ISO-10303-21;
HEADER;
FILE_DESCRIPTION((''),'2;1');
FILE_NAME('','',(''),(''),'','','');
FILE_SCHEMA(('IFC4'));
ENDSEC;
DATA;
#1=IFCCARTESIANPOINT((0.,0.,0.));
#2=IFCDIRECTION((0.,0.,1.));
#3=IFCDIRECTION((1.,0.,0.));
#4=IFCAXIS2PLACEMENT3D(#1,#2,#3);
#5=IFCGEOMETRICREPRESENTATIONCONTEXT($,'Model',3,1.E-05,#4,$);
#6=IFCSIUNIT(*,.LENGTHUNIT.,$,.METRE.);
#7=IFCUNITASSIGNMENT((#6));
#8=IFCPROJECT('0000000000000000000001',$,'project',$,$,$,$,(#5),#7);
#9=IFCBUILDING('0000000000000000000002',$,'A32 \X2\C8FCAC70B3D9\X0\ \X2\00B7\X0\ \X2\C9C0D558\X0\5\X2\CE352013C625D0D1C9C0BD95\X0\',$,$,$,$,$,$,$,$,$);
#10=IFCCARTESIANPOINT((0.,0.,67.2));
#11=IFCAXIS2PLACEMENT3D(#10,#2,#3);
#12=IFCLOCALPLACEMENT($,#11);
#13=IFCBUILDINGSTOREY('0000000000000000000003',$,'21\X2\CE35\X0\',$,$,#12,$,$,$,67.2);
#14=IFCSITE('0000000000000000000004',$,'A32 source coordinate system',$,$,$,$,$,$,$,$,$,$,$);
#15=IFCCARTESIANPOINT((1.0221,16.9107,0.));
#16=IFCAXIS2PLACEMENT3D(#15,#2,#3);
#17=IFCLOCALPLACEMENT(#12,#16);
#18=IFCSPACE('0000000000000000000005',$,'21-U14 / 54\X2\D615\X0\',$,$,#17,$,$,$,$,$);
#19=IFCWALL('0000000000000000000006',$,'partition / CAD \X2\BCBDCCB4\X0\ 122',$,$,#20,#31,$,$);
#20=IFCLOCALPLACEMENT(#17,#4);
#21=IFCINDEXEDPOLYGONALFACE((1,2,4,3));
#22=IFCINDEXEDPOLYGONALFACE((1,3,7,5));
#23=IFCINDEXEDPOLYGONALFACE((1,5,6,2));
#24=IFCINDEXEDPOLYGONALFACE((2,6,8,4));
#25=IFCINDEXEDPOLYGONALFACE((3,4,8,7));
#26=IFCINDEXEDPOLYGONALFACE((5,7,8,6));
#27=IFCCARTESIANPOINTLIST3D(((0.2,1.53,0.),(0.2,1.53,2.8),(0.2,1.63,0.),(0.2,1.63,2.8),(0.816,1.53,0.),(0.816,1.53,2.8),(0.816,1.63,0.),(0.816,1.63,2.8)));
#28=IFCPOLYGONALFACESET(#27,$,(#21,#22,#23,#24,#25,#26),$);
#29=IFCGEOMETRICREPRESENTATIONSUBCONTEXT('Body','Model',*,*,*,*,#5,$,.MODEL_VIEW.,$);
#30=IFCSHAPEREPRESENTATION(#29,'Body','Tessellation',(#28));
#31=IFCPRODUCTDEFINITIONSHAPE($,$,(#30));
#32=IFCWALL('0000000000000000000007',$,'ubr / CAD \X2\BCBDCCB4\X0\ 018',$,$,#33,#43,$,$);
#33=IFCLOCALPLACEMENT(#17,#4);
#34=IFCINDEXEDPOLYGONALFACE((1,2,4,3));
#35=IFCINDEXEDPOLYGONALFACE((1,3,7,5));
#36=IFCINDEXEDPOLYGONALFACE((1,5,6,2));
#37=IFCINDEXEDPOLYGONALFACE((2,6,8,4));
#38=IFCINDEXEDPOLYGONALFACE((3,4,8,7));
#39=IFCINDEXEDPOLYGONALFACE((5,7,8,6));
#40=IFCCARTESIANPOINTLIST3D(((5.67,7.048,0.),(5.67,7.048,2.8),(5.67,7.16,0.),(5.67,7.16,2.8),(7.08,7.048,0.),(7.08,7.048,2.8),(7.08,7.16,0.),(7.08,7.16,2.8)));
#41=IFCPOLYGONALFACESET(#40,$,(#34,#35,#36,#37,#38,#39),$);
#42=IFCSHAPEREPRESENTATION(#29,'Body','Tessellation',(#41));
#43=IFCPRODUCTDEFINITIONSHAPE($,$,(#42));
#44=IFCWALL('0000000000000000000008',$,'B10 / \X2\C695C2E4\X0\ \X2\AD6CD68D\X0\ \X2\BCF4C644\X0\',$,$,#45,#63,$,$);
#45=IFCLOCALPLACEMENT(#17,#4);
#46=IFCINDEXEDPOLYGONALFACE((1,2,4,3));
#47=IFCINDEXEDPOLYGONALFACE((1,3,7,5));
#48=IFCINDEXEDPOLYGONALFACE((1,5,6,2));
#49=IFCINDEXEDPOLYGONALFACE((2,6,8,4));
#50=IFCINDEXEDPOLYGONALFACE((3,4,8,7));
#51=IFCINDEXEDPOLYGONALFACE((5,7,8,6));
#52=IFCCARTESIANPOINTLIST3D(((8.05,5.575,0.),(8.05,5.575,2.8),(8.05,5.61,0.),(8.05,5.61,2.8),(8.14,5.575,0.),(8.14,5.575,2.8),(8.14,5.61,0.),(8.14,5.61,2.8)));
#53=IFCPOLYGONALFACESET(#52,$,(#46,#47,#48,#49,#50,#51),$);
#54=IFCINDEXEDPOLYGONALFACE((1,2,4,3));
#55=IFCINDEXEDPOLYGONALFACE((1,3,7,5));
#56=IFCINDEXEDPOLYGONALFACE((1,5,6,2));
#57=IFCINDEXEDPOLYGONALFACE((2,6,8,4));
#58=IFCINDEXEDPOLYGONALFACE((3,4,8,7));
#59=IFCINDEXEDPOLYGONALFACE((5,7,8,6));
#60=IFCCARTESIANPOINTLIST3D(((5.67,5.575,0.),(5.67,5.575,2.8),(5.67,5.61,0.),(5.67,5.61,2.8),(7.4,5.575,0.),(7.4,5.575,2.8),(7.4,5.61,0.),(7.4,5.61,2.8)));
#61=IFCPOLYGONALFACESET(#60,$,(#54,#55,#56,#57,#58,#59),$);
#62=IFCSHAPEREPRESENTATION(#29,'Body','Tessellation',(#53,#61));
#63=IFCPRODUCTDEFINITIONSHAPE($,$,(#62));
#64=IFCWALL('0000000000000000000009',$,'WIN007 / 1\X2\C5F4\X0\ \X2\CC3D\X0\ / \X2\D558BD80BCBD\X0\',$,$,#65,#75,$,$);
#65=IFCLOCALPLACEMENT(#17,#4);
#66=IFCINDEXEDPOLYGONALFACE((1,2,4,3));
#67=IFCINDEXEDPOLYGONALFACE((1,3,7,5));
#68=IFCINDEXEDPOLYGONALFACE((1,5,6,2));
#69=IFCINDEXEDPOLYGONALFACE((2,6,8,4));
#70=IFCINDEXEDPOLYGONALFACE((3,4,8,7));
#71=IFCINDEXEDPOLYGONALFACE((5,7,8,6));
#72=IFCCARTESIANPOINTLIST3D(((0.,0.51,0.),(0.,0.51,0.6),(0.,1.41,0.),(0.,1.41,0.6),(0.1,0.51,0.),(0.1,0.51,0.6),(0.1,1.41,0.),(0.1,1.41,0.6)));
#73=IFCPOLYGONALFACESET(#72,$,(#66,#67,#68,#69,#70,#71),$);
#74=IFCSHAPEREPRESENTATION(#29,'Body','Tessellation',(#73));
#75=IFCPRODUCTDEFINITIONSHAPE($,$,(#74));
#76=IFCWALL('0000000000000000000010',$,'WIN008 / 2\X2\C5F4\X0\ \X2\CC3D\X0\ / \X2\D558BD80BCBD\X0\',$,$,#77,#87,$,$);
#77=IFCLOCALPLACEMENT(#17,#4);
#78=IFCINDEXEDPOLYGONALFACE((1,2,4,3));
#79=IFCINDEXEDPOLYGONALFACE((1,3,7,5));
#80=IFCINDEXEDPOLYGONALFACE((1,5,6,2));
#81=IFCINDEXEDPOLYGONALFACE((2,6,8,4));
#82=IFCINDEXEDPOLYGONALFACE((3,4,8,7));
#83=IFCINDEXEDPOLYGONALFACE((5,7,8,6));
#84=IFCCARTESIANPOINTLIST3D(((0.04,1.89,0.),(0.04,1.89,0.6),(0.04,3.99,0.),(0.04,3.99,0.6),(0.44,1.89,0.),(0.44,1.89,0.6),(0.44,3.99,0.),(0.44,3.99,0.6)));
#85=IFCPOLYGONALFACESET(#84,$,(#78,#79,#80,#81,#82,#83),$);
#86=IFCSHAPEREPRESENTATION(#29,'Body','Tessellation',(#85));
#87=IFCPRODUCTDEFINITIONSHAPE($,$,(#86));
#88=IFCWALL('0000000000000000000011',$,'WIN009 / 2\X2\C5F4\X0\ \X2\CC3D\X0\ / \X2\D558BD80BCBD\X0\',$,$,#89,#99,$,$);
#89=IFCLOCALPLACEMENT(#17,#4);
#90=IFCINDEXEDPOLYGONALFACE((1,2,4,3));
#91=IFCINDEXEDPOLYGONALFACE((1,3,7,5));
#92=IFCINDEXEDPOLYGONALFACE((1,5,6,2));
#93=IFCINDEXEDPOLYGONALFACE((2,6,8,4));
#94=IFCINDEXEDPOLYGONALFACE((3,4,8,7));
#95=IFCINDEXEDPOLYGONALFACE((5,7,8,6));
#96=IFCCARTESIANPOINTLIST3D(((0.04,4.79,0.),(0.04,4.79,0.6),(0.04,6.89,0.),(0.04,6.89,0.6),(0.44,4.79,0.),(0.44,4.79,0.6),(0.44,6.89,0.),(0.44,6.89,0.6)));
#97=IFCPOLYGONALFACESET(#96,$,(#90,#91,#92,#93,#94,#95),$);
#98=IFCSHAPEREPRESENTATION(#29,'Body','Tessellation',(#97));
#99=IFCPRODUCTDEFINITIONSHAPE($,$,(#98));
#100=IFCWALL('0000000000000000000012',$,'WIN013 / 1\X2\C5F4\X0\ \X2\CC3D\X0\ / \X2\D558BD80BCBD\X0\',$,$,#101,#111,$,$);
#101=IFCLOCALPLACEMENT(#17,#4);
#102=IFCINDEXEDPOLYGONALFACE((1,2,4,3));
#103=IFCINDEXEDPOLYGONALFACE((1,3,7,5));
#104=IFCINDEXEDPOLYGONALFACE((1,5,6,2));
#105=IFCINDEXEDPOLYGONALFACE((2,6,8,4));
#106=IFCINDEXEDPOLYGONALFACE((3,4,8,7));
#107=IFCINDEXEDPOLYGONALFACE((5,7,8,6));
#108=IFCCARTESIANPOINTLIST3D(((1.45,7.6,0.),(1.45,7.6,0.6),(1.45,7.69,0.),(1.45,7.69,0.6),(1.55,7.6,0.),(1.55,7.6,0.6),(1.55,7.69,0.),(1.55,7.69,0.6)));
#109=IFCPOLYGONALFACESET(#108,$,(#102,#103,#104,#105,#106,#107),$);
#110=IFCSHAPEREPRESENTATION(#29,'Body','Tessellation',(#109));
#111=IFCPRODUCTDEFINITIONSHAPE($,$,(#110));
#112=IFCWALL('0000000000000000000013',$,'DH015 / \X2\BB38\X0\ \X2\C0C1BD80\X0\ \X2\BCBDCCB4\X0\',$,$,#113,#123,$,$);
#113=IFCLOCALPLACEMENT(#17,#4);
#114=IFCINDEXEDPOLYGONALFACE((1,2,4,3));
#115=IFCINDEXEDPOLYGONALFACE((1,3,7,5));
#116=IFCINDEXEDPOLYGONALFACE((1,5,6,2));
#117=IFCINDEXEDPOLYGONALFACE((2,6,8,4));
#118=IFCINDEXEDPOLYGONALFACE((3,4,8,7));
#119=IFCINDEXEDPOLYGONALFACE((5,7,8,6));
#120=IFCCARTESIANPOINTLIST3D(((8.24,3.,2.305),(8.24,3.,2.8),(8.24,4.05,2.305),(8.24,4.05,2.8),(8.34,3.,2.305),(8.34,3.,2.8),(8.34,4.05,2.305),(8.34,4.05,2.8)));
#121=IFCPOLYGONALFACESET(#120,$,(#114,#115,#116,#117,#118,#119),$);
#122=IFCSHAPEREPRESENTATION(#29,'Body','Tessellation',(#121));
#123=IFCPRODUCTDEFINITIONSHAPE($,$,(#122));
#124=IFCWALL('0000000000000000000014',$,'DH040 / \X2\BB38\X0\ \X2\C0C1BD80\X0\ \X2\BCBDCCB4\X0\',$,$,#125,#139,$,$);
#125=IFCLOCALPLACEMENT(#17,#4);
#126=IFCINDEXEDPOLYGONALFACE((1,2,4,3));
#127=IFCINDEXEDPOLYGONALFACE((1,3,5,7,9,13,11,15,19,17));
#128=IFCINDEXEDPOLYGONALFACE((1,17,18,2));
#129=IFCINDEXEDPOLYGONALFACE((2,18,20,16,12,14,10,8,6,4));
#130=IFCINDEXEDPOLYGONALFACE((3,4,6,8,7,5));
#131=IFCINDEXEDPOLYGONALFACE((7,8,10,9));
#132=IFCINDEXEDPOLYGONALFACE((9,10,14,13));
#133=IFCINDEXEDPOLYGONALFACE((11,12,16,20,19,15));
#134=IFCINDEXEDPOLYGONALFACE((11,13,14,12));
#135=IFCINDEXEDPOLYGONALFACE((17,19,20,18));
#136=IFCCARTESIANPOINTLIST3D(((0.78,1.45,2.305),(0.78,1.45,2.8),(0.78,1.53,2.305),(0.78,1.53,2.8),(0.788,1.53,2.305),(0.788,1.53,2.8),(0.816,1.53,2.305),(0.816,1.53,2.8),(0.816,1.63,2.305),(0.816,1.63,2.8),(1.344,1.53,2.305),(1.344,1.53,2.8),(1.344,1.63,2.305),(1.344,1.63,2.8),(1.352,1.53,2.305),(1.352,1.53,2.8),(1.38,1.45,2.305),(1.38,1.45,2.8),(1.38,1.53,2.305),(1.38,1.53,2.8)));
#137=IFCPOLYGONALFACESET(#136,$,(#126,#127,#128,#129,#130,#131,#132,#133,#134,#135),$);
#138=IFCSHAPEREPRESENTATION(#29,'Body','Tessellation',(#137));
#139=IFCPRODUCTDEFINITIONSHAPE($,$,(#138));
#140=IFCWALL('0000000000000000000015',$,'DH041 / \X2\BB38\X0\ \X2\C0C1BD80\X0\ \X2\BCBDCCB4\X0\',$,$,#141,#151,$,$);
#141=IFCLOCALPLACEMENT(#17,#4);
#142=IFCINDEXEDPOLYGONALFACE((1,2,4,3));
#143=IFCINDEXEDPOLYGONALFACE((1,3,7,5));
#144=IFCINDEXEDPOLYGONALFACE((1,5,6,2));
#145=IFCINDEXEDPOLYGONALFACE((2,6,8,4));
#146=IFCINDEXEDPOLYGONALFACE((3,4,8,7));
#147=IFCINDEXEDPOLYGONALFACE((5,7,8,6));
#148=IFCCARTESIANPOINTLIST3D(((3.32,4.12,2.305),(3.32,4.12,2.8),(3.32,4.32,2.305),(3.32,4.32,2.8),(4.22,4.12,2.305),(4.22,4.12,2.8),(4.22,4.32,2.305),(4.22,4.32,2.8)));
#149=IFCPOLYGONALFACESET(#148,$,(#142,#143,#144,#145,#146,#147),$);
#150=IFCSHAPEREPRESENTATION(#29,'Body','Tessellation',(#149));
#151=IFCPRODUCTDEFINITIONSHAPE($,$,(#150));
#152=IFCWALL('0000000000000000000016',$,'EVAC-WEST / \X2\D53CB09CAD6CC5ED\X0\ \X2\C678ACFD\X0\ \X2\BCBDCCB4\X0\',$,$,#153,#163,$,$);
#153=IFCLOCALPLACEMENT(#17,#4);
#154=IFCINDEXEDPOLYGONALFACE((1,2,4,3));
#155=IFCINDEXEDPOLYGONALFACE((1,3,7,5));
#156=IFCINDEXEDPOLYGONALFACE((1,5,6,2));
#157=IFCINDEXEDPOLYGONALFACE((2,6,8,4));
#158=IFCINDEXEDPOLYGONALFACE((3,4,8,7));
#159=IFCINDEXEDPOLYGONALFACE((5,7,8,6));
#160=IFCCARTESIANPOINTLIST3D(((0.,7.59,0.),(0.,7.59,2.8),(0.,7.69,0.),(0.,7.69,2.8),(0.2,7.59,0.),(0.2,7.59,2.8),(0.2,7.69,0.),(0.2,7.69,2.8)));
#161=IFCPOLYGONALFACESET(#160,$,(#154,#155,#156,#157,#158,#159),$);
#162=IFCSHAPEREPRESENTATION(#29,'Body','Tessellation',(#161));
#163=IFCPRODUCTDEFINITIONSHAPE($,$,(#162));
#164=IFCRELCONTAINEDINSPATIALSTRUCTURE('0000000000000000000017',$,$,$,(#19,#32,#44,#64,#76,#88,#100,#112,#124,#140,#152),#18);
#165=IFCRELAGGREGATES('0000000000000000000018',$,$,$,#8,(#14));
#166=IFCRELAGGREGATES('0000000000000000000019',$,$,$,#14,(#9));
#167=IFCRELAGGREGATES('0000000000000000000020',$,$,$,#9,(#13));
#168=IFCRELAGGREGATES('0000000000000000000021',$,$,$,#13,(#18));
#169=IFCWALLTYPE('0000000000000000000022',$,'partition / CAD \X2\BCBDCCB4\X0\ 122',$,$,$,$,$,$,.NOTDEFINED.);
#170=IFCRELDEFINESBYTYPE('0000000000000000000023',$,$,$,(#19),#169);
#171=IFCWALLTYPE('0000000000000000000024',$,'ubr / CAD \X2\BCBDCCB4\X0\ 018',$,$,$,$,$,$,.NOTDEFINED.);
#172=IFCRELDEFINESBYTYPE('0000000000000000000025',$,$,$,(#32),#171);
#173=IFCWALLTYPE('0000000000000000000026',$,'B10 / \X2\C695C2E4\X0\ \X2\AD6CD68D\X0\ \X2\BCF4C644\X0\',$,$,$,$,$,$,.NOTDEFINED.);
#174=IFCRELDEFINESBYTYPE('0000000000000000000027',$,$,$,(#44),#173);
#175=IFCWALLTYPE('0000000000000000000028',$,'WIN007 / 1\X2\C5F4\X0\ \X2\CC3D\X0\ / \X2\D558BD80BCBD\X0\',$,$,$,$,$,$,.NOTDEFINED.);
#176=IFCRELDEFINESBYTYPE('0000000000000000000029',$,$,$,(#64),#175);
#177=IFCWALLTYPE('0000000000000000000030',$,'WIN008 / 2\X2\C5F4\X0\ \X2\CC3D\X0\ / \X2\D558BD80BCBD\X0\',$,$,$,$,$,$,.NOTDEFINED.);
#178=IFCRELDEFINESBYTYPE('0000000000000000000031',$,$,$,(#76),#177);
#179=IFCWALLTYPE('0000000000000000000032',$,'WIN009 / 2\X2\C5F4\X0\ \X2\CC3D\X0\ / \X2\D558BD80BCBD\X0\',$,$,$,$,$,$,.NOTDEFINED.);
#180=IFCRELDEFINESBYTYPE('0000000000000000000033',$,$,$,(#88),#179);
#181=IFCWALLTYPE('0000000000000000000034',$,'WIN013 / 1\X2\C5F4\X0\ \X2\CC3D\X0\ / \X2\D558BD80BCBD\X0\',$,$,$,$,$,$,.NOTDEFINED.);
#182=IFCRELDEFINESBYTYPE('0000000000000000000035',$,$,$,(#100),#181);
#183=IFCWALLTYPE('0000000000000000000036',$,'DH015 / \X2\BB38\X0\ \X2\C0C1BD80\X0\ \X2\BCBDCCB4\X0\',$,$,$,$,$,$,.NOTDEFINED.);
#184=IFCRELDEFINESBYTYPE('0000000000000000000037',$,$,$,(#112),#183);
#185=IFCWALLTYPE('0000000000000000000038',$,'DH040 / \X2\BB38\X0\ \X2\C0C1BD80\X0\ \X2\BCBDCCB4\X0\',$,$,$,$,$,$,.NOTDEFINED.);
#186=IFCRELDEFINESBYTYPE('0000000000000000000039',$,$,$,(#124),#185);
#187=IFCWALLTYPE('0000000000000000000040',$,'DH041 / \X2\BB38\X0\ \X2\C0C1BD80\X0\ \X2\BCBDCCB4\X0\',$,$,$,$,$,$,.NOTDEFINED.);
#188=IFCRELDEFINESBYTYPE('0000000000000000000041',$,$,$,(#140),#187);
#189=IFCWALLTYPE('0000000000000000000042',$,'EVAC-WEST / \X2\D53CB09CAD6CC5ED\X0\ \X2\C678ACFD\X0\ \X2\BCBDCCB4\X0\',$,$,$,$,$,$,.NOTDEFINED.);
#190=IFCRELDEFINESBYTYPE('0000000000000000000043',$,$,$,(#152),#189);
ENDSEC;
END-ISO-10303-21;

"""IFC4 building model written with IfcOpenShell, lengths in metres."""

from ifc_helpers import new_model, si_unit, frame, origin, origin_with_axes, place, context, subcontext, project, spatial, polyline, outline, extrude, source, transform, mapped, type_object, type_shapes, element, save


model = new_model("IFC4")

# Units and contexts
model_context = context("Model", 3, precision=1e-05, world=origin_with_axes())
body_context = subcontext(model_context, "Body", "Model", "MODEL_VIEW")
ifc_project = project(units=[si_unit("LENGTHUNIT", "METRE")], contexts=[model_context])

# Site, building, storey, space
site = spatial("IfcSite", under=ifc_project, Name="A32 source coordinate system")
building = spatial("IfcBuilding", under=site, Name="A32 주거동 · 지하5층–옥탑지붕")
storey_placement = place(None, frame((0.0, 0.0, 67.2), z_axis=(0.0, 0.0, 1.0), x_axis=(1.0, 0.0, 0.0)))
storey = spatial("IfcBuildingStorey", under=building, at=storey_placement, Name="21층", Elevation=67.2)
space_placement = place(storey_placement, frame((1.0221, 16.9107, 0.0), z_axis=(0.0, 0.0, 1.0), x_axis=(1.0, 0.0, 0.0)))
space = spatial("IfcSpace", under=storey, at=space_placement, Name="21-U14 / 54형")

# Walls
wall_type_1 = type_object("IfcWallType", Name="partition / CAD 벽체 122", PredefinedType="NOTDEFINED")
shared_shape_1 = source(origin(), body_context, "Body", "SweptSolid", [
    extrude(outline(polyline([(0.816, 1.63), (0.816, 1.53), (0.2, 1.53), (0.2, 1.63), (0.816, 1.63)])), origin(), (0.0, 0.0, 1.0), 2.8),
])
type_shapes(wall_type_1, [shared_shape_1])
wall_1_placement = place(space_placement, origin_with_axes())
element("IfcWall", 1, at=wall_1_placement, inside=space, type_object=wall_type_1, Name="partition / CAD 벽체 122", context=body_context, shape_type="MappedRepresentation", body=[
    mapped(shared_shape_1, transform((0.0, 0.0, 0.0), scale=1.0)),
])
wall_type_2 = type_object("IfcWallType", Name="ubr / CAD 벽체 018", PredefinedType="NOTDEFINED")
shared_shape_2 = source(origin(), body_context, "Body", "SweptSolid", [
    extrude(outline(polyline([(5.67, 7.16), (7.08, 7.16), (7.08, 7.048), (5.67, 7.048), (5.67, 7.16)])), origin(), (0.0, 0.0, 1.0), 2.8),
])
type_shapes(wall_type_2, [shared_shape_2])
wall_2_placement = place(space_placement, origin_with_axes())
element("IfcWall", 2, at=wall_2_placement, inside=space, type_object=wall_type_2, Name="ubr / CAD 벽체 018", context=body_context, shape_type="MappedRepresentation", body=[
    mapped(shared_shape_2, transform((0.0, 0.0, 0.0), scale=1.0)),
])
wall_type_3 = type_object("IfcWallType", Name="B10 / 욕실 구획 보완", PredefinedType="NOTDEFINED")
shared_shape_3 = source(origin(), body_context, "Body", "SweptSolid", [
    extrude(outline(polyline([(8.14, 5.575), (8.05, 5.575), (8.05, 5.61), (8.14, 5.61), (8.14, 5.575)])), origin(), (0.0, 0.0, 1.0), 2.8),
    extrude(outline(polyline([(7.4, 5.575), (5.67, 5.575), (5.67, 5.61), (7.4, 5.61), (7.4, 5.575)])), origin(), (0.0, 0.0, 1.0), 2.8),
])
type_shapes(wall_type_3, [shared_shape_3])
wall_3_placement = place(space_placement, origin_with_axes())
element("IfcWall", 3, at=wall_3_placement, inside=space, type_object=wall_type_3, Name="B10 / 욕실 구획 보완", context=body_context, shape_type="MappedRepresentation", body=[
    mapped(shared_shape_3, transform((0.0, 0.0, 0.0), scale=1.0)),
])
wall_type_4 = type_object("IfcWallType", Name="WIN007 / 1열 창 / 하부벽", PredefinedType="NOTDEFINED")
shared_shape_4 = source(origin(), body_context, "Body", "SweptSolid", [
    extrude(outline(polyline([(0.1, 1.41), (0.1, 0.51), (0.0, 0.51), (0.0, 1.41), (0.1, 1.41)])), origin(), (0.0, 0.0, 1.0), 0.6),
])
type_shapes(wall_type_4, [shared_shape_4])
wall_4_placement = place(space_placement, origin_with_axes())
element("IfcWall", 4, at=wall_4_placement, inside=space, type_object=wall_type_4, Name="WIN007 / 1열 창 / 하부벽", context=body_context, shape_type="MappedRepresentation", body=[
    mapped(shared_shape_4, transform((0.0, 0.0, 0.0), scale=1.0)),
])
wall_type_5 = type_object("IfcWallType", Name="WIN008 / 2열 창 / 하부벽", PredefinedType="NOTDEFINED")
shared_shape_5 = source(origin(), body_context, "Body", "SweptSolid", [
    extrude(outline(polyline([(0.44, 3.99), (0.44, 1.89), (0.04, 1.89), (0.04, 3.99), (0.44, 3.99)])), origin(), (0.0, 0.0, 1.0), 0.6),
])
type_shapes(wall_type_5, [shared_shape_5])
wall_5_placement = place(space_placement, origin_with_axes())
element("IfcWall", 5, at=wall_5_placement, inside=space, type_object=wall_type_5, Name="WIN008 / 2열 창 / 하부벽", context=body_context, shape_type="MappedRepresentation", body=[
    mapped(shared_shape_5, transform((0.0, 0.0, 0.0), scale=1.0)),
])
wall_type_6 = type_object("IfcWallType", Name="WIN009 / 2열 창 / 하부벽", PredefinedType="NOTDEFINED")
shared_shape_6 = source(origin(), body_context, "Body", "SweptSolid", [
    extrude(outline(polyline([(0.44, 6.89), (0.44, 4.79), (0.04, 4.79), (0.04, 6.89), (0.44, 6.89)])), origin(), (0.0, 0.0, 1.0), 0.6),
])
type_shapes(wall_type_6, [shared_shape_6])
wall_6_placement = place(space_placement, origin_with_axes())
element("IfcWall", 6, at=wall_6_placement, inside=space, type_object=wall_type_6, Name="WIN009 / 2열 창 / 하부벽", context=body_context, shape_type="MappedRepresentation", body=[
    mapped(shared_shape_6, transform((0.0, 0.0, 0.0), scale=1.0)),
])
wall_type_7 = type_object("IfcWallType", Name="WIN013 / 1열 창 / 하부벽", PredefinedType="NOTDEFINED")
shared_shape_7 = source(origin(), body_context, "Body", "SweptSolid", [
    extrude(outline(polyline([(1.55, 7.6), (1.45, 7.6), (1.45, 7.69), (1.55, 7.69), (1.55, 7.6)])), origin(), (0.0, 0.0, 1.0), 0.6),
])
type_shapes(wall_type_7, [shared_shape_7])
wall_7_placement = place(space_placement, origin_with_axes())
element("IfcWall", 7, at=wall_7_placement, inside=space, type_object=wall_type_7, Name="WIN013 / 1열 창 / 하부벽", context=body_context, shape_type="MappedRepresentation", body=[
    mapped(shared_shape_7, transform((0.0, 0.0, 0.0), scale=1.0)),
])
wall_type_8 = type_object("IfcWallType", Name="DH015 / 문 상부 벽체", PredefinedType="NOTDEFINED")
shared_shape_8 = source(origin(), body_context, "Body", "SweptSolid", [
    extrude(outline(polyline([(8.34, 3.0), (8.24, 3.0), (8.24, 4.05), (8.34, 4.05), (8.34, 3.0)])), frame((0.0, 0.0, 2.305)), (0.0, 0.0, 1.0), 0.495),
])
type_shapes(wall_type_8, [shared_shape_8])
wall_8_placement = place(space_placement, origin_with_axes())
element("IfcWall", 8, at=wall_8_placement, inside=space, type_object=wall_type_8, Name="DH015 / 문 상부 벽체", context=body_context, shape_type="MappedRepresentation", body=[
    mapped(shared_shape_8, transform((0.0, 0.0, 0.0), scale=1.0)),
])
wall_type_9 = type_object("IfcWallType", Name="DH040 / 문 상부 벽체", PredefinedType="NOTDEFINED")
shared_shape_9 = source(origin(), body_context, "Body", "SweptSolid", [
    extrude(outline(polyline([(0.816, 1.63), (1.344, 1.63), (1.344, 1.53), (1.352, 1.53), (1.38, 1.53), (1.38, 1.45), (0.78, 1.45), (0.78, 1.53), (0.788, 1.53), (0.816, 1.53), (0.816, 1.63)])), frame((0.0, 0.0, 2.305)), (0.0, 0.0, 1.0), 0.495),
])
type_shapes(wall_type_9, [shared_shape_9])
wall_9_placement = place(space_placement, origin_with_axes())
element("IfcWall", 9, at=wall_9_placement, inside=space, type_object=wall_type_9, Name="DH040 / 문 상부 벽체", context=body_context, shape_type="MappedRepresentation", body=[
    mapped(shared_shape_9, transform((0.0, 0.0, 0.0), scale=1.0)),
])
wall_type_10 = type_object("IfcWallType", Name="DH041 / 문 상부 벽체", PredefinedType="NOTDEFINED")
shared_shape_10 = source(origin(), body_context, "Body", "SweptSolid", [
    extrude(outline(polyline([(4.22, 4.12), (3.32, 4.12), (3.32, 4.32), (4.22, 4.32), (4.22, 4.12)])), frame((0.0, 0.0, 2.305)), (0.0, 0.0, 1.0), 0.495),
])
type_shapes(wall_type_10, [shared_shape_10])
wall_10_placement = place(space_placement, origin_with_axes())
element("IfcWall", 10, at=wall_10_placement, inside=space, type_object=wall_type_10, Name="DH041 / 문 상부 벽체", context=body_context, shape_type="MappedRepresentation", body=[
    mapped(shared_shape_10, transform((0.0, 0.0, 0.0), scale=1.0)),
])
wall_type_11 = type_object("IfcWallType", Name="EVAC-WEST / 피난구역 외곽 벽체", PredefinedType="NOTDEFINED")
shared_shape_11 = source(origin(), body_context, "Body", "SweptSolid", [
    extrude(outline(polyline([(0.2, 7.59), (0.0, 7.59), (0.0, 7.69), (0.2, 7.69), (0.2, 7.59)])), origin(), (0.0, 0.0, 1.0), 2.8),
])
type_shapes(wall_type_11, [shared_shape_11])
wall_11_placement = place(space_placement, origin_with_axes())
element("IfcWall", 11, at=wall_11_placement, inside=space, type_object=wall_type_11, Name="EVAC-WEST / 피난구역 외곽 벽체", context=body_context, shape_type="MappedRepresentation", body=[
    mapped(shared_shape_11, transform((0.0, 0.0, 0.0), scale=1.0)),
])

save(model, "model.ifc")
